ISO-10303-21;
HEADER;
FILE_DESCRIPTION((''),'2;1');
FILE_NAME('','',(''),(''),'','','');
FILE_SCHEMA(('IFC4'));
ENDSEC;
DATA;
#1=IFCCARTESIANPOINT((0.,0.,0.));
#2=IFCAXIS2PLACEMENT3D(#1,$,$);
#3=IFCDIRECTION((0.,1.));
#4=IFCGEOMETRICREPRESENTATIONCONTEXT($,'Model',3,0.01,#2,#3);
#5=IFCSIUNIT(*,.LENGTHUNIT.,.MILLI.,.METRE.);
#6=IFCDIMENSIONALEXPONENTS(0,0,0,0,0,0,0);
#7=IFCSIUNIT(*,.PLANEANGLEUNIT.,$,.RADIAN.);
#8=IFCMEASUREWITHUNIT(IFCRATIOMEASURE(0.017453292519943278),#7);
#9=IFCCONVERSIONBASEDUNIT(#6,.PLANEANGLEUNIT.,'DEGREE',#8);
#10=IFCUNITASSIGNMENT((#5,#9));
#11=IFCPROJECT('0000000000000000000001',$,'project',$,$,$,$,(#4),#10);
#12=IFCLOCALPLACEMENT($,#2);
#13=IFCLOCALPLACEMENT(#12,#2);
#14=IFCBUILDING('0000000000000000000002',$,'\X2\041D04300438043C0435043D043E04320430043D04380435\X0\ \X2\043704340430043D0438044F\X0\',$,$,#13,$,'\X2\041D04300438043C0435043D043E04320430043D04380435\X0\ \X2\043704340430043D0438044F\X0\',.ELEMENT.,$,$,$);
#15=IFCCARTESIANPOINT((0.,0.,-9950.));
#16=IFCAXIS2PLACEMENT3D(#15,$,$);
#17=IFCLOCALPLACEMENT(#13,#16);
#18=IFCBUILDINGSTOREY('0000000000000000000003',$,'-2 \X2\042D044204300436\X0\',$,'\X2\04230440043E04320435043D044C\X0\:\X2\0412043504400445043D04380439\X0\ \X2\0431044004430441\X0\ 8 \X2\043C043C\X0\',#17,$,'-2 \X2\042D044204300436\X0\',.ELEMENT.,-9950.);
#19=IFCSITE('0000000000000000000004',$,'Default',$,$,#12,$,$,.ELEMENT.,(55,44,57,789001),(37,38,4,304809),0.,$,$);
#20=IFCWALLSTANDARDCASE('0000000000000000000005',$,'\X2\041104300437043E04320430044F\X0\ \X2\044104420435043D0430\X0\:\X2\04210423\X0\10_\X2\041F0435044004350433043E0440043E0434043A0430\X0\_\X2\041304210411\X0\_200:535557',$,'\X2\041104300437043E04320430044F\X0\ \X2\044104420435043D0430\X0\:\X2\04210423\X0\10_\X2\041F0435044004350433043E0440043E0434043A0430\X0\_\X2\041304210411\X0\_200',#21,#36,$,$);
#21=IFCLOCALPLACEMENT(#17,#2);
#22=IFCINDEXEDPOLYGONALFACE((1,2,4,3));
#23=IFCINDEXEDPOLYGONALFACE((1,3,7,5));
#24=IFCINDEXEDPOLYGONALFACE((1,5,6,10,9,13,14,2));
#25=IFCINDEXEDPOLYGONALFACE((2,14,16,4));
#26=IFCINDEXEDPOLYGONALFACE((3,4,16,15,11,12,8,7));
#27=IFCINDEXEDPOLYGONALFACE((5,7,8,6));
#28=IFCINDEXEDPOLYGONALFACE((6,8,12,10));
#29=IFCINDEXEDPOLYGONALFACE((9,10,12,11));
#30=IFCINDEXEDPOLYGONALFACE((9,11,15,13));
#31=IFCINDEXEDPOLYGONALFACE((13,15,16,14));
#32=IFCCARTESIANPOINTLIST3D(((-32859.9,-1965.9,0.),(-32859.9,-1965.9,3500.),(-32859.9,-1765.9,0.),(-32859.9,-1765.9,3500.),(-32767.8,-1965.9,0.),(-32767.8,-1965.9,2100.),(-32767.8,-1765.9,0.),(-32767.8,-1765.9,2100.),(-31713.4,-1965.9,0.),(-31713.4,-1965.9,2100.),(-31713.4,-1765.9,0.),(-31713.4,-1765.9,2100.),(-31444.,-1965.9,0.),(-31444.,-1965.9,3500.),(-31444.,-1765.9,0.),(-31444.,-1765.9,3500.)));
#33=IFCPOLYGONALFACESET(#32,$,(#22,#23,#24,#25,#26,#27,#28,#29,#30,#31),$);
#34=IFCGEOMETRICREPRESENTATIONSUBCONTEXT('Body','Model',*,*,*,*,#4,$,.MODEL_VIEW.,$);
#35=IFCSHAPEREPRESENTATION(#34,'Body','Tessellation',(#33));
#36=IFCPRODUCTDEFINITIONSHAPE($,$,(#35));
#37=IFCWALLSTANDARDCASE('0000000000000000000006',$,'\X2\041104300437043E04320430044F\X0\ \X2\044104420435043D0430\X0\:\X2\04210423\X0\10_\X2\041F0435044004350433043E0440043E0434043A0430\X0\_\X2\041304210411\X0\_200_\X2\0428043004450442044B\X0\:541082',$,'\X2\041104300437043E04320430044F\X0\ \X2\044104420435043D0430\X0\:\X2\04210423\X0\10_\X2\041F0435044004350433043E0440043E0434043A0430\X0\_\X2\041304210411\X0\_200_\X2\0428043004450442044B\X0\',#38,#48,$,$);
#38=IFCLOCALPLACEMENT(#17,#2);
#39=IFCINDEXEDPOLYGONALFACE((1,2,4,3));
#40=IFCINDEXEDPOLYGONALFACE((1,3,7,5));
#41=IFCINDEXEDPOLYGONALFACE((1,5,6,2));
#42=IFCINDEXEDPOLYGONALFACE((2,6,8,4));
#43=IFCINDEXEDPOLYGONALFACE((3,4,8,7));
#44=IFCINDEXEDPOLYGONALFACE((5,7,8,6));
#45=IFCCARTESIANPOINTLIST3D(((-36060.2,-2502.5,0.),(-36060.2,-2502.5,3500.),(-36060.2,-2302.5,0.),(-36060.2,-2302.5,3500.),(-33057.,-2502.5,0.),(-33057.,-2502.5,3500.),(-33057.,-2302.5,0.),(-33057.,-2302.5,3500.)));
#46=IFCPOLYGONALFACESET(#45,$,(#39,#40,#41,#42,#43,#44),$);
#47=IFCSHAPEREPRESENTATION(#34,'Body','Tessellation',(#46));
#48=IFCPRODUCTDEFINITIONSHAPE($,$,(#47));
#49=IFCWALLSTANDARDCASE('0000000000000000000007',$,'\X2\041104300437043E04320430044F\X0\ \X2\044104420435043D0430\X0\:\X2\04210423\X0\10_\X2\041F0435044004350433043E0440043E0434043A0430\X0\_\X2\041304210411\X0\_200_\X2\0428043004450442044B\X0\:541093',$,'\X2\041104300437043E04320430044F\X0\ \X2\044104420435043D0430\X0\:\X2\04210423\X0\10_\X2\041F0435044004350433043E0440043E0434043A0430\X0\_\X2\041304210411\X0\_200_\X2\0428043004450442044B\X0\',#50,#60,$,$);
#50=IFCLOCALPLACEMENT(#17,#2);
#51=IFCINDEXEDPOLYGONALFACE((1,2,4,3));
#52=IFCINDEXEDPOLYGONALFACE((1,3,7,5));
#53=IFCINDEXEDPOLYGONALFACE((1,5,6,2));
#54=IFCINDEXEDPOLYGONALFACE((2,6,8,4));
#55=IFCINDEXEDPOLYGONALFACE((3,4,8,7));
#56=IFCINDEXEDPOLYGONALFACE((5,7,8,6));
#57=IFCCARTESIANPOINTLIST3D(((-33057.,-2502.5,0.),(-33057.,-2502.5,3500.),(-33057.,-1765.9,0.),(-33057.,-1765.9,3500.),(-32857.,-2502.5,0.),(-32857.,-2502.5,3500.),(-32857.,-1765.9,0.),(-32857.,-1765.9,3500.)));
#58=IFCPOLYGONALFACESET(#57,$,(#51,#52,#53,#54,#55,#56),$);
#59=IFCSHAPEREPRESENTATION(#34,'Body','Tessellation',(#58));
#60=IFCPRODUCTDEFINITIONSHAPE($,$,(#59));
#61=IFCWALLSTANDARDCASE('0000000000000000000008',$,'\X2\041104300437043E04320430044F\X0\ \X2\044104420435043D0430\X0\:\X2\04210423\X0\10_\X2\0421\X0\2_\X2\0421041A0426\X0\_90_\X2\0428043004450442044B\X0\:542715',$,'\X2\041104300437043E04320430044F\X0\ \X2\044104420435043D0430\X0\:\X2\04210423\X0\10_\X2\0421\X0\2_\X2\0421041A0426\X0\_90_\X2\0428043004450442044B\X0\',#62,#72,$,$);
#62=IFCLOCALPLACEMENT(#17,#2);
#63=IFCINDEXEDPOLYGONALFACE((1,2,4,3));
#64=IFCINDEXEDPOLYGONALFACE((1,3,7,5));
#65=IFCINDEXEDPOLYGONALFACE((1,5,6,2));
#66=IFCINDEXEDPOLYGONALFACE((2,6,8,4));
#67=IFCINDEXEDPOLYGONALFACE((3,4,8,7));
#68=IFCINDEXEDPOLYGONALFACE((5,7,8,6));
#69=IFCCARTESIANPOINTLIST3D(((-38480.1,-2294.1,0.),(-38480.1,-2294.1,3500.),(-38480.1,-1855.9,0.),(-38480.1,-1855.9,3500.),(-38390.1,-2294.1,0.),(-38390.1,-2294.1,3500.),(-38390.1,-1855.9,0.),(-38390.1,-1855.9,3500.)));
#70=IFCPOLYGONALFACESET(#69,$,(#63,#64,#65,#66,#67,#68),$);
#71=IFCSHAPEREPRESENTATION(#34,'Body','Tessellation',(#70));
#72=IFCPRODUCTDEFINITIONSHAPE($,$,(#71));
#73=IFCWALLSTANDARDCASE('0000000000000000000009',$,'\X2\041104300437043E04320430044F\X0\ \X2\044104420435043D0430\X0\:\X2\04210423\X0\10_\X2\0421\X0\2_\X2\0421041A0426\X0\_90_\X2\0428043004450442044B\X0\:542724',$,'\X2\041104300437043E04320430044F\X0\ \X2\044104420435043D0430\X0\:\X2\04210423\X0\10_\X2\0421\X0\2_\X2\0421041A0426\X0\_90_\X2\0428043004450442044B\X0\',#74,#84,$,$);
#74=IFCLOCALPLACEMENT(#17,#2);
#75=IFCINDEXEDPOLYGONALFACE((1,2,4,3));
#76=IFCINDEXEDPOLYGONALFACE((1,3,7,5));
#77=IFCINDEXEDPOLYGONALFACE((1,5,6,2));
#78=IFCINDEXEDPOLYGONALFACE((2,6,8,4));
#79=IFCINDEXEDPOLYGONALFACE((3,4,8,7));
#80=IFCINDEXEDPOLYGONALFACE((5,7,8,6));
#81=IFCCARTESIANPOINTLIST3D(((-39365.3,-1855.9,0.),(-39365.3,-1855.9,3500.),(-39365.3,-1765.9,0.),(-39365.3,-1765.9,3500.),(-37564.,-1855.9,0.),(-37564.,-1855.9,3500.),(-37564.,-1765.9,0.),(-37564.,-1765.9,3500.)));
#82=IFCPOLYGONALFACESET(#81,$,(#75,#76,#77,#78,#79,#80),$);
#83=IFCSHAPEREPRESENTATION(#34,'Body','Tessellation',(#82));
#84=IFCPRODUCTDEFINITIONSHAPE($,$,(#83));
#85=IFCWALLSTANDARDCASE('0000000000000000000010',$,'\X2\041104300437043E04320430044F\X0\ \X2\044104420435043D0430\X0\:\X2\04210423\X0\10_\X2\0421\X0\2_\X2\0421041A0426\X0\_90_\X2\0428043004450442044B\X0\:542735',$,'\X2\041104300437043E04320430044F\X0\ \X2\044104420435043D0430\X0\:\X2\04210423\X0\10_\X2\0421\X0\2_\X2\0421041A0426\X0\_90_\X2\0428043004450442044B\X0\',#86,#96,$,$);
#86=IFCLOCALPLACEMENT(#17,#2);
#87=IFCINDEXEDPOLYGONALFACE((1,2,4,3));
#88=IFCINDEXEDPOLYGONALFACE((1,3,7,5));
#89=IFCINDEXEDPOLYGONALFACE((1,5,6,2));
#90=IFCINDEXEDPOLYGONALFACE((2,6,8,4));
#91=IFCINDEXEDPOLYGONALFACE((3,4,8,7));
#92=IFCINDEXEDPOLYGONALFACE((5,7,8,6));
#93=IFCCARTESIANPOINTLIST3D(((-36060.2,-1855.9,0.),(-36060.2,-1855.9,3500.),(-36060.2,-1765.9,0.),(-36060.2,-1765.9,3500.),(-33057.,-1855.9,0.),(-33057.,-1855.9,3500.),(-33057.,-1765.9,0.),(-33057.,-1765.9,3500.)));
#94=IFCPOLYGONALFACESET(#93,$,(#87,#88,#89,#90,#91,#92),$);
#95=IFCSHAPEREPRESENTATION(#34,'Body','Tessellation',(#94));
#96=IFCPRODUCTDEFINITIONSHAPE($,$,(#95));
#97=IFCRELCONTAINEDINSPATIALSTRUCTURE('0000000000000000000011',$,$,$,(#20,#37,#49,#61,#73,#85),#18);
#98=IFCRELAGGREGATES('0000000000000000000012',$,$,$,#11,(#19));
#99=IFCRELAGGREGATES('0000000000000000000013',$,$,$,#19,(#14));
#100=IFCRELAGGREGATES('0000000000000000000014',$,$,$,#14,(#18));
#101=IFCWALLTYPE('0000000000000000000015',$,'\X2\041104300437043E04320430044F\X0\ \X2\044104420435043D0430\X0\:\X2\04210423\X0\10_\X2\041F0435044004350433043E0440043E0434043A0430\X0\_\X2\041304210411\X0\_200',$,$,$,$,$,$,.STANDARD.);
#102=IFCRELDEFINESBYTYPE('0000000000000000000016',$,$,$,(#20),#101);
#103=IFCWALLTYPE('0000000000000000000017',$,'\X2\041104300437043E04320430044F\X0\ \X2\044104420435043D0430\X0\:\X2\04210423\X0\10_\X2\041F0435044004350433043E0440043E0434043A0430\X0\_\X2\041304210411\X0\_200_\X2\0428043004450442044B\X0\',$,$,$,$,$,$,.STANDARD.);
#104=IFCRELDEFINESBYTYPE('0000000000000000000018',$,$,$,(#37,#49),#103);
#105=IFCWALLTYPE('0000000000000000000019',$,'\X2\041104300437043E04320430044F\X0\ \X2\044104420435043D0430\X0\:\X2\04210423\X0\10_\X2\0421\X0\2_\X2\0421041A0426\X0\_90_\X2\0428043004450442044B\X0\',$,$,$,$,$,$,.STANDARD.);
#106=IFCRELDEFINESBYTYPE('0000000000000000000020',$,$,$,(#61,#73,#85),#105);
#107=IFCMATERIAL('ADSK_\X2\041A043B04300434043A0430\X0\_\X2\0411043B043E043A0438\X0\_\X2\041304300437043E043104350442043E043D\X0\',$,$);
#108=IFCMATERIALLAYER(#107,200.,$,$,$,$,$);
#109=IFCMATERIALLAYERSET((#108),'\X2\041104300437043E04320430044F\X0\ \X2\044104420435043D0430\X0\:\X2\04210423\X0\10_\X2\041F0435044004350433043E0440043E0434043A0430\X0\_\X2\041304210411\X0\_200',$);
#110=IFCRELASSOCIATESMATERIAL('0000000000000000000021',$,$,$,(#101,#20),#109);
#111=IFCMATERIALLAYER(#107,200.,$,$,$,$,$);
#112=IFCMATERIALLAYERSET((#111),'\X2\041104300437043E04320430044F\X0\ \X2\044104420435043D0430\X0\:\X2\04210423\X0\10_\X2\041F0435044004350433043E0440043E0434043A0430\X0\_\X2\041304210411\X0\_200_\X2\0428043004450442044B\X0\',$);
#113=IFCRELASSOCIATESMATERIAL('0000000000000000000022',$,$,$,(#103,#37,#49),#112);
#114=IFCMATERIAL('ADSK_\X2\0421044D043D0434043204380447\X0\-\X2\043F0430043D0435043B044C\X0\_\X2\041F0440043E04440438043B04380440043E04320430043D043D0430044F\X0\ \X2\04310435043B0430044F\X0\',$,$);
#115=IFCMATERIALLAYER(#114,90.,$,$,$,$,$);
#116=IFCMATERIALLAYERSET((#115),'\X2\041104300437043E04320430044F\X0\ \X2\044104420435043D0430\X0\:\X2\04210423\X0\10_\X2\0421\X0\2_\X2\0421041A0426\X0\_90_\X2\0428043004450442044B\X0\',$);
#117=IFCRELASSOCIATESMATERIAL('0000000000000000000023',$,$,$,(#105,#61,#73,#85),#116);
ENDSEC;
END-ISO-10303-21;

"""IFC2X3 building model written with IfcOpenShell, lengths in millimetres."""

from ifc_helpers import new_model, entity, si_unit, converted_unit, direction, frame, frame_2d, origin, place, context, subcontext, project, spatial, rectangle, extrude, material, layer, layer_set, layer_usage, type_object, element, save


model = new_model("IFC2X3")

# Units and contexts
model_context = context("Model", 3, precision=0.01, world=origin(), true_north=direction((0.0, 1.0)))
body_context = subcontext(model_context, "Body", "Model", "MODEL_VIEW")
ifc_project = project(units=[si_unit("LENGTHUNIT", "METRE", prefix="MILLI"), converted_unit("PLANEANGLEUNIT", "DEGREE", entity("IfcRatioMeasure", 0.017453292519943278), si_unit("PLANEANGLEUNIT", "RADIAN"), dimensions=[0, 0, 0, 0, 0, 0, 0])], contexts=[model_context])

# Site, building, storey
site_placement = place(None, origin())
site = spatial("IfcSite", under=ifc_project, at=site_placement, Name="Default", CompositionType="ELEMENT", RefLatitude=(55, 44, 57, 789001), RefLongitude=(37, 38, 4, 304809), RefElevation=0.0)
building_placement = place(site_placement, origin())
building = spatial("IfcBuilding", under=site, at=building_placement, Name="Наименование здания", LongName="Наименование здания", CompositionType="ELEMENT")
storey_placement = place(building_placement, frame((0.0, 0.0, -9950.0)))
storey = spatial("IfcBuildingStorey", under=building, at=storey_placement, Name="-2 Этаж", ObjectType="Уровень:Верхний брус 8 мм", LongName="-2 Этаж", CompositionType="ELEMENT", Elevation=-9950.0)

# Shared definitions
ifc_material_1 = material(Name="ADSK_Сэндвич-панель_Профилированная белая")

# Shared definitions
ifc_material_2 = material(Name="ADSK_Кладка_Блоки_Газобетон")
ifc_layer_1 = layer(ifc_material_2, 200.0)
ifc_layer_set_1 = layer_set([ifc_layer_1], Name="Базовая стена:СУ10_Перегородка_ГСБ_200")
ifc_layer_usage_1 = layer_usage(ifc_layer_set_1, "AXIS2", "NEGATIVE", 100.0)
wall_type_1 = type_object("IfcWallType", Name="Базовая стена:СУ10_Перегородка_ГСБ_200", PredefinedType="STANDARD", material=ifc_layer_set_1)

# Wall, opening
wall_1_placement = place(storey_placement, frame((-31444.0, -1865.9, 0.0), z_axis=(0.0, 0.0, 1.0), x_axis=(-1.0, 0.0, 0.0)))
wall_1 = element("IfcWallStandardCase", 1, at=wall_1_placement, inside=storey, type_object=wall_type_1, material=ifc_layer_usage_1, Name="Базовая стена:СУ10_Перегородка_ГСБ_200:535557", ObjectType="Базовая стена:СУ10_Перегородка_ГСБ_200", context=body_context, shape_type="SweptSolid", body=[
    extrude(rectangle(XDim=1415.9, YDim=200.0, at=frame_2d((707.9, 0.0), x_axis=(1.0, 0.0))), origin(), (0.0, 0.0, 1.0), 3500.0),
])
opening_1_placement = place(wall_1_placement, origin())
element("IfcOpeningElement", 2, at=opening_1_placement, cuts=wall_1, ObjectType="Opening", context=body_context, shape_type="SweptSolid", body=[
    extrude(rectangle(XDim=2100.0, YDim=1054.4, at=frame_2d((0.0, 0.0), x_axis=(1.0, 0.0))), frame((796.6, -100.0, 1050.0), z_axis=(0.0, 1.0, 0.0), x_axis=(0.0, 0.0, -1.0)), (0.0, 0.0, 1.0), 200.0),
])

# Walls
ifc_layer_2 = layer(ifc_material_2, 200.0)
ifc_layer_set_2 = layer_set([ifc_layer_2], Name="Базовая стена:СУ10_Перегородка_ГСБ_200_Шахты")
ifc_layer_usage_2 = layer_usage(ifc_layer_set_2, "AXIS2", "NEGATIVE", 100.0)
wall_type_2 = type_object("IfcWallType", Name="Базовая стена:СУ10_Перегородка_ГСБ_200_Шахты", PredefinedType="STANDARD", material=ifc_layer_set_2)
wall_2_placement = place(storey_placement, frame((-36060.2, -2402.5, 0.0)))
element("IfcWallStandardCase", 3, at=wall_2_placement, inside=storey, type_object=wall_type_2, material=ifc_layer_usage_2, Name="Базовая стена:СУ10_Перегородка_ГСБ_200_Шахты:541082", ObjectType="Базовая стена:СУ10_Перегородка_ГСБ_200_Шахты", context=body_context, shape_type="SweptSolid", body=[
    extrude(rectangle(XDim=3003.2, YDim=200.0, at=frame_2d((1501.6, 0.0), x_axis=(-1.0, 0.0))), origin(), (0.0, 0.0, 1.0), 3500.0),
])
wall_3_placement = place(storey_placement, frame((-32957.0, -1765.9, 0.0), z_axis=(0.0, 0.0, 1.0), x_axis=(0.0, -1.0, 0.0)))
element("IfcWallStandardCase", 4, at=wall_3_placement, inside=storey, type_object=wall_type_2, material=ifc_layer_usage_2, Name="Базовая стена:СУ10_Перегородка_ГСБ_200_Шахты:541093", ObjectType="Базовая стена:СУ10_Перегородка_ГСБ_200_Шахты", context=body_context, shape_type="SweptSolid", body=[
    extrude(rectangle(XDim=736.6, YDim=200.0, at=frame_2d((368.3, 0.0), x_axis=(-1.0, 0.0))), origin(), (0.0, 0.0, 1.0), 3500.0),
])
ifc_layer_3 = layer(ifc_material_1, 90.0)
ifc_layer_set_3 = layer_set([ifc_layer_3], Name="Базовая стена:СУ10_С2_СКЦ_90_Шахты")
ifc_layer_usage_3 = layer_usage(ifc_layer_set_3, "AXIS2", "NEGATIVE", 45.0)
wall_type_3 = type_object("IfcWallType", Name="Базовая стена:СУ10_С2_СКЦ_90_Шахты", PredefinedType="STANDARD", material=ifc_layer_set_3)
wall_4_placement = place(storey_placement, frame((-38435.1, -2294.1, 0.0), z_axis=(0.0, 0.0, 1.0), x_axis=(0.0, 1.0, 0.0)))
element("IfcWallStandardCase", 5, at=wall_4_placement, inside=storey, type_object=wall_type_3, material=ifc_layer_usage_3, Name="Базовая стена:СУ10_С2_СКЦ_90_Шахты:542715", ObjectType="Базовая стена:СУ10_С2_СКЦ_90_Шахты", context=body_context, shape_type="SweptSolid", body=[
    extrude(rectangle(XDim=438.2, YDim=90.0, at=frame_2d((219.1, 0.0), x_axis=(-1.0, 0.0))), origin(), (0.0, 0.0, 1.0), 3500.0),
])
wall_5_placement = place(storey_placement, frame((-37564.0, -1810.9, 0.0), z_axis=(0.0, 0.0, 1.0), x_axis=(-1.0, 0.0, 0.0)))
element("IfcWallStandardCase", 6, at=wall_5_placement, inside=storey, type_object=wall_type_3, material=ifc_layer_usage_3, Name="Базовая стена:СУ10_С2_СКЦ_90_Шахты:542724", ObjectType="Базовая стена:СУ10_С2_СКЦ_90_Шахты", context=body_context, shape_type="SweptSolid", body=[
    extrude(rectangle(XDim=1801.3, YDim=90.0, at=frame_2d((900.6, 0.0), x_axis=(-1.0, 0.0))), origin(), (0.0, 0.0, 1.0), 3500.0),
])
wall_6_placement = place(storey_placement, frame((-33057.0, -1810.9, 0.0), z_axis=(0.0, 0.0, 1.0), x_axis=(-1.0, 0.0, 0.0)))
element("IfcWallStandardCase", 7, at=wall_6_placement, inside=storey, type_object=wall_type_3, material=ifc_layer_usage_3, Name="Базовая стена:СУ10_С2_СКЦ_90_Шахты:542735", ObjectType="Базовая стена:СУ10_С2_СКЦ_90_Шахты", context=body_context, shape_type="SweptSolid", body=[
    extrude(rectangle(XDim=3003.2, YDim=90.0, at=frame_2d((1501.6, 0.0), x_axis=(-1.0, 0.0))), origin(), (0.0, 0.0, 1.0), 3500.0),
])

save(model, "model.ifc")
